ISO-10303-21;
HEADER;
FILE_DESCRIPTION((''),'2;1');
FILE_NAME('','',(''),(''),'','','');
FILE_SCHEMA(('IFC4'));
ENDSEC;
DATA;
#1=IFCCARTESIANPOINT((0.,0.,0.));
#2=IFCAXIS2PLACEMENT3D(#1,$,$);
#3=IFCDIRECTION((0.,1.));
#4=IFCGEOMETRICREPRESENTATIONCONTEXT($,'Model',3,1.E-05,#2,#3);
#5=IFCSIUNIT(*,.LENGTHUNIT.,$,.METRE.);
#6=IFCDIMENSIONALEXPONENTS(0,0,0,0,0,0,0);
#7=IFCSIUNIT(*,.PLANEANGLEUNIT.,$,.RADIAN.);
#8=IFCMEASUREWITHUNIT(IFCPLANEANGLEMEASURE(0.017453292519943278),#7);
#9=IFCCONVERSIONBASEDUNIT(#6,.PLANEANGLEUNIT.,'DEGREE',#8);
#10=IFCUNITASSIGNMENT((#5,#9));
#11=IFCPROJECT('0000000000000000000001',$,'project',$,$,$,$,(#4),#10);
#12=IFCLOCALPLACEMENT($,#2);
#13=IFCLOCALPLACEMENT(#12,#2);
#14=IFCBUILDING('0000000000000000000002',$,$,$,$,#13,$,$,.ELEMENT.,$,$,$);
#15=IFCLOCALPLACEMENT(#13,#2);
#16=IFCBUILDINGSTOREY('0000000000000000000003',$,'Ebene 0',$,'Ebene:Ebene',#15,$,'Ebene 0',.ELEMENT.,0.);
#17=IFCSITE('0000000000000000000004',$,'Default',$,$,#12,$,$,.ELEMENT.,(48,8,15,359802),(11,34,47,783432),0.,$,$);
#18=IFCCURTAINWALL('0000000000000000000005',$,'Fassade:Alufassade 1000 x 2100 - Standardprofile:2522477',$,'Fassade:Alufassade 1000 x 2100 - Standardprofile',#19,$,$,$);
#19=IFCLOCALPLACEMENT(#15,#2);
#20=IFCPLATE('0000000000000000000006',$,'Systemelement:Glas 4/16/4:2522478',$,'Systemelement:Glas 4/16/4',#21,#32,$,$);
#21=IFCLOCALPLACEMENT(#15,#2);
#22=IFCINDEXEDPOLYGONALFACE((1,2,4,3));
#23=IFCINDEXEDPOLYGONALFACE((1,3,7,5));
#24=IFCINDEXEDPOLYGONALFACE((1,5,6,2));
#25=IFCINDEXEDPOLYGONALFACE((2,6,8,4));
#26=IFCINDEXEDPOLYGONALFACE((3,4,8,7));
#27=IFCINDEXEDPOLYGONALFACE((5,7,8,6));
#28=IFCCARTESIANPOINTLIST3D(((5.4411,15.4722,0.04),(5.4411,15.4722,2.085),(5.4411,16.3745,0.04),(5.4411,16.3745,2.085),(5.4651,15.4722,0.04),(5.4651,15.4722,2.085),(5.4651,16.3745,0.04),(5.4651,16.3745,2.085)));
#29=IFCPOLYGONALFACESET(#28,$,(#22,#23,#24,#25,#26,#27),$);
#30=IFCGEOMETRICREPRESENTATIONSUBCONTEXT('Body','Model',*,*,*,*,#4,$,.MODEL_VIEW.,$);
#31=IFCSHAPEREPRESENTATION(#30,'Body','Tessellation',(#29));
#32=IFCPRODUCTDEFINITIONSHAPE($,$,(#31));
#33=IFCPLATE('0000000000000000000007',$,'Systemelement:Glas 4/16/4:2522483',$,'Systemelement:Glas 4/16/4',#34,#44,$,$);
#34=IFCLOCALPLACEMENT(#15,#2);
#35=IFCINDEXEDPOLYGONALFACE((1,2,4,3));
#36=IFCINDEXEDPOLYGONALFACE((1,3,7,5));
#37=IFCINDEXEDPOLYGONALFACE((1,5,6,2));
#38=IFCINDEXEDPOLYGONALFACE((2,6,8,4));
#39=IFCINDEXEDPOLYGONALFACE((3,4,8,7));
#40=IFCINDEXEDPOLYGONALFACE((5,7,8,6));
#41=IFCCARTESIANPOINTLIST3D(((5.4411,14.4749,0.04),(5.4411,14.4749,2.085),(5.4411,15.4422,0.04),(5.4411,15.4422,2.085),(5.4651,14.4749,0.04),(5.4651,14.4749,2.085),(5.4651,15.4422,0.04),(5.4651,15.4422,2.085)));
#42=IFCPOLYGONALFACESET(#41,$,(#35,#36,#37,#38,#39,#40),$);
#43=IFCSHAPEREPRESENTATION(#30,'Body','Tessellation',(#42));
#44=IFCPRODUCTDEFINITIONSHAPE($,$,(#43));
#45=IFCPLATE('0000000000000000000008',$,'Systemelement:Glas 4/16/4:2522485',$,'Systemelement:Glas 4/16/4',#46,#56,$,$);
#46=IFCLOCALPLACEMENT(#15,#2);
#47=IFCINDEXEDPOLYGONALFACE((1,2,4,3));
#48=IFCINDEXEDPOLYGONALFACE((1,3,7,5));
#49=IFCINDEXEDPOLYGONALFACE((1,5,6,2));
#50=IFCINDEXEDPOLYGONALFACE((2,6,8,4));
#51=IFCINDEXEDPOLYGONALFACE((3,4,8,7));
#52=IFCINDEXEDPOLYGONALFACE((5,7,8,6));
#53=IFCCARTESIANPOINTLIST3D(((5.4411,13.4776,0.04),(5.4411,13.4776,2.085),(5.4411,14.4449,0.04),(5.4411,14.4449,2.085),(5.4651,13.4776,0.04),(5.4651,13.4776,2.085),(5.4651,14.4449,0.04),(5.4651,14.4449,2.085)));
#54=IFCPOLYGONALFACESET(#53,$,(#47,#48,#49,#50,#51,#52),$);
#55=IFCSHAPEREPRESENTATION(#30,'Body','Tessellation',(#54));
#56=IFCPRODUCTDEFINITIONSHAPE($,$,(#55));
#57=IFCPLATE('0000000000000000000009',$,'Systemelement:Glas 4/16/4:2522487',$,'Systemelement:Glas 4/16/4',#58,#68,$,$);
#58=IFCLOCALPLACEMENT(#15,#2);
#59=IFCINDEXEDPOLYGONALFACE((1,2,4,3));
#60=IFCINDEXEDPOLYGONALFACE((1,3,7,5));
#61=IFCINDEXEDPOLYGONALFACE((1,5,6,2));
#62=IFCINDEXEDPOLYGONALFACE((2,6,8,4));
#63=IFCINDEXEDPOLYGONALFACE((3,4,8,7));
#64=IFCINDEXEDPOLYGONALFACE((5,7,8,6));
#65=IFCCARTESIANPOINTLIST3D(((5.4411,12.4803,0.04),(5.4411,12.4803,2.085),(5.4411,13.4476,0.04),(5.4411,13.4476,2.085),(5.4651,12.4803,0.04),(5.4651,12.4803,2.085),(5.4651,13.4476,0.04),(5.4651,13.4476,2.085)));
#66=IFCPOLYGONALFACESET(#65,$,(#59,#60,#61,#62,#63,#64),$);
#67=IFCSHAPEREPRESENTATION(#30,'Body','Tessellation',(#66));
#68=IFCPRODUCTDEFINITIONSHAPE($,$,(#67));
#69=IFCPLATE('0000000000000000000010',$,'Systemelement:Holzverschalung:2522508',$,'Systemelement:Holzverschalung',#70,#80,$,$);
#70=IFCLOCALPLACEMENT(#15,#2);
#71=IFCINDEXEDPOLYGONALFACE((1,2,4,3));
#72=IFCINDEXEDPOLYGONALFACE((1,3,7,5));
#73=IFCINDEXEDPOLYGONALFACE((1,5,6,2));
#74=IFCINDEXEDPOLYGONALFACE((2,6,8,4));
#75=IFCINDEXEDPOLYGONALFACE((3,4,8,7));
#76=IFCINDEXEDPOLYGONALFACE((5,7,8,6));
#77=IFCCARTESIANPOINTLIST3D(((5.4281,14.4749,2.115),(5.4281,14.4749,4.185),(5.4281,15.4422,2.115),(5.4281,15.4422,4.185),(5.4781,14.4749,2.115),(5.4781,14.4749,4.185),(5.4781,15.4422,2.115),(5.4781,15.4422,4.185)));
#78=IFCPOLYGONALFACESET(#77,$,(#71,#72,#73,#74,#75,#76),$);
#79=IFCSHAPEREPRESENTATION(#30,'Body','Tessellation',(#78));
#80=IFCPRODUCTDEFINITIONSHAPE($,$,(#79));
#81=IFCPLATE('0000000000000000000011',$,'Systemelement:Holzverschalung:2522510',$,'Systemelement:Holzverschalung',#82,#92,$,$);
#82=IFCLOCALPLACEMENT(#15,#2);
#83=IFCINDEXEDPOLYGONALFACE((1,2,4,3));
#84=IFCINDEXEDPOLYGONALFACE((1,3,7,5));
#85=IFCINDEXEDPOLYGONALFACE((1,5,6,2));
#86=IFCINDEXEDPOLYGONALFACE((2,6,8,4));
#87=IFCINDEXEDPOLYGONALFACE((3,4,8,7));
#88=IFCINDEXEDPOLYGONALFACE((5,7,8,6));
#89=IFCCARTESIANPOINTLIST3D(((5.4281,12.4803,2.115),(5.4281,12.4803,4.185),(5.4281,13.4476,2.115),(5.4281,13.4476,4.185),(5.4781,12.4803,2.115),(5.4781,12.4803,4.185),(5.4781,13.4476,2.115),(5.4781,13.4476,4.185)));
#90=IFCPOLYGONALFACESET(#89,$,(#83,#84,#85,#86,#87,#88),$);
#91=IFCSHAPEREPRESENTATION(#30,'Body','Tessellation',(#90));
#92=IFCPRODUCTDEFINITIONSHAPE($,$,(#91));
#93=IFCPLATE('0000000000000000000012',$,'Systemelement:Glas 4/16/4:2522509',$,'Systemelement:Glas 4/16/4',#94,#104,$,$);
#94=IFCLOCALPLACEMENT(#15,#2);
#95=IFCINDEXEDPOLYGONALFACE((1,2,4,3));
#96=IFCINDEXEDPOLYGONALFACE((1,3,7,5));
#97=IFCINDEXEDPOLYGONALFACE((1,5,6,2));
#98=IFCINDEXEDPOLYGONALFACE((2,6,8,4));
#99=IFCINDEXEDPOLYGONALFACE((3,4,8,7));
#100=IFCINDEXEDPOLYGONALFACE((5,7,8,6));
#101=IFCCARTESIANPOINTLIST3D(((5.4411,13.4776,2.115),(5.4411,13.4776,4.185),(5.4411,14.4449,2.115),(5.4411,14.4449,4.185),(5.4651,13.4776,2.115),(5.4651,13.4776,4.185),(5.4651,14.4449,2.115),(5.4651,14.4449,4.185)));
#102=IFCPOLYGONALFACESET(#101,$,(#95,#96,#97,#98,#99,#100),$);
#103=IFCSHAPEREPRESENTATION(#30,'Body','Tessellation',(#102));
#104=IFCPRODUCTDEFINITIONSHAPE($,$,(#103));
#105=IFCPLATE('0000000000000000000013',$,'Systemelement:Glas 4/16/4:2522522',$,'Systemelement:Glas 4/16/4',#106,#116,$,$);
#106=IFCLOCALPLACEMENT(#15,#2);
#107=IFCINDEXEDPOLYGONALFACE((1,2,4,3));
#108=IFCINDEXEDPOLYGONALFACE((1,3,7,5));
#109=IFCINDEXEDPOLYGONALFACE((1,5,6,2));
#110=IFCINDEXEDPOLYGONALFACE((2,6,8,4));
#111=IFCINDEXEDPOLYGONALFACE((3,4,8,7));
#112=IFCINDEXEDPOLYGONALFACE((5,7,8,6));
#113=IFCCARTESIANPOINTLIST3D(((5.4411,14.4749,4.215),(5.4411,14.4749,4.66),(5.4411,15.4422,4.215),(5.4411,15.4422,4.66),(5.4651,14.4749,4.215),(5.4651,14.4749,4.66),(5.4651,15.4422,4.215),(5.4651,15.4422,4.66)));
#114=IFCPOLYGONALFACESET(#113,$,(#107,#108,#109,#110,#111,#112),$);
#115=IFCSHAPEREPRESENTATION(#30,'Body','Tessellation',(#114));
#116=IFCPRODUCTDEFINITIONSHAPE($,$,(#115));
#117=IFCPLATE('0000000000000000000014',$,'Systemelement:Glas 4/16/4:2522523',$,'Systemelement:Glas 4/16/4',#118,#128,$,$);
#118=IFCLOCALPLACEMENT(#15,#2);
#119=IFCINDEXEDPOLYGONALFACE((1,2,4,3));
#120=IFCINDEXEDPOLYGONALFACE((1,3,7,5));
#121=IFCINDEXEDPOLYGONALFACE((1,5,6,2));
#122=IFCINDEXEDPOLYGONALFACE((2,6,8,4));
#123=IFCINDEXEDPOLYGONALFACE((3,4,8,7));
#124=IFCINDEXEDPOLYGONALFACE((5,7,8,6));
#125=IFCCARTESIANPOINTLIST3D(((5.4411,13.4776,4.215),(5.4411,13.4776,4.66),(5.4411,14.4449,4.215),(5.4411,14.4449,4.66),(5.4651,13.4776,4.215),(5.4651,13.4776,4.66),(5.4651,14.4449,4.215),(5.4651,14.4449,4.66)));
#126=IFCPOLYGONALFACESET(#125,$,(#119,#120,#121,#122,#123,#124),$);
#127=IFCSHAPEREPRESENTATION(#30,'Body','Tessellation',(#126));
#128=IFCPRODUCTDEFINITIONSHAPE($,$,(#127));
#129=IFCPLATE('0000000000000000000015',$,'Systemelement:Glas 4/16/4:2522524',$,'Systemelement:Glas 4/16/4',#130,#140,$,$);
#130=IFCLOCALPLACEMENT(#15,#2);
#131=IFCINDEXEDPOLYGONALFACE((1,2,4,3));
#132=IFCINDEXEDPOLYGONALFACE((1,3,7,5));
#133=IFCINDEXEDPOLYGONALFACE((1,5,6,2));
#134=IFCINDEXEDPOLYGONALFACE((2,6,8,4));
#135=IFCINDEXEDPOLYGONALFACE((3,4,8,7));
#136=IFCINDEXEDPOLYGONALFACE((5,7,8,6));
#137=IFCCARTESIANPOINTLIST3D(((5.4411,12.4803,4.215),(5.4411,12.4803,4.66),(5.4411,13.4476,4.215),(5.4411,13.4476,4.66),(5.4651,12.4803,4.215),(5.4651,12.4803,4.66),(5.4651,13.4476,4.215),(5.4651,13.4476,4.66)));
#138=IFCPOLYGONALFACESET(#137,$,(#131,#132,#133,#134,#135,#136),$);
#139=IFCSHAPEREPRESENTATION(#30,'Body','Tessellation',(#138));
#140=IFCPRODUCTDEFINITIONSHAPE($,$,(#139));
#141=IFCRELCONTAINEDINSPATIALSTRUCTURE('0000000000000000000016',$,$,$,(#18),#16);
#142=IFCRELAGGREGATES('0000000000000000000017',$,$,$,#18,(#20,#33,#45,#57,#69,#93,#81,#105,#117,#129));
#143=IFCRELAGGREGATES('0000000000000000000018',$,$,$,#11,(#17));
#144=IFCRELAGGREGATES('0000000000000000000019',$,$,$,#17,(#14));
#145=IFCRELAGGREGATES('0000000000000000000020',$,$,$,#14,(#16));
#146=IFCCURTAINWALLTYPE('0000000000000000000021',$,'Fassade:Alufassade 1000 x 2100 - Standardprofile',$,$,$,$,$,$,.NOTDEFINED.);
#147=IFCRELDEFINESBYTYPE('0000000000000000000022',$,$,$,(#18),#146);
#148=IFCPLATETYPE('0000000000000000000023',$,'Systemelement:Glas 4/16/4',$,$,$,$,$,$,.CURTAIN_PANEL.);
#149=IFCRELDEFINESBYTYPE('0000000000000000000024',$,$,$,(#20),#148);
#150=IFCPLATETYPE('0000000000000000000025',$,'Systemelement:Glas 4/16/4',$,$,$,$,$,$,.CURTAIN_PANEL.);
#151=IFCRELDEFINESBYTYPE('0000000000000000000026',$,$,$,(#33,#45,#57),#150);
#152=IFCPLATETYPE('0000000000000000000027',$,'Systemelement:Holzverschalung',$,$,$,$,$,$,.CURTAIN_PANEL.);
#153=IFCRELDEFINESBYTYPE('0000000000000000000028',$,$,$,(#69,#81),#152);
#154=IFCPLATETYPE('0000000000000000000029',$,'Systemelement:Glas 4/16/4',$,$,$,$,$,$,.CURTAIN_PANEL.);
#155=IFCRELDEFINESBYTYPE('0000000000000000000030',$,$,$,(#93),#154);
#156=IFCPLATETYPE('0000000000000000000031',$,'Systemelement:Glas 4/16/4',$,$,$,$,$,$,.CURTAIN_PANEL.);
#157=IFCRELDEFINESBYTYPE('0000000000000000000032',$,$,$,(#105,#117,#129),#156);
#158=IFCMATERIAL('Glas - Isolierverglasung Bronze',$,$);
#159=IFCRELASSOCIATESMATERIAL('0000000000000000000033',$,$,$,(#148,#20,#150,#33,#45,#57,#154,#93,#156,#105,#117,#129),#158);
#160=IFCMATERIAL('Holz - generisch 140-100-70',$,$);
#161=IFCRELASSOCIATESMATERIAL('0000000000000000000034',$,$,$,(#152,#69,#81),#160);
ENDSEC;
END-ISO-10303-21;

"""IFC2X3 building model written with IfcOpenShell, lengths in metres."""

from ifc_helpers import new_model, entity, si_unit, converted_unit, direction, frame, origin, origin_2d_with_axis, place, context, subcontext, project, spatial, rectangle, extrude, source, transform, mapped, material, type_object, type_shapes, element, aggregate, save


model = new_model("IFC2X3")

# Units and contexts
model_context = context("Model", 3, precision=1e-05, world=origin(), true_north=direction((0.0, 1.0)))
body_context = subcontext(model_context, "Body", "Model", "MODEL_VIEW")
ifc_project = project(units=[si_unit("LENGTHUNIT", "METRE"), converted_unit("PLANEANGLEUNIT", "DEGREE", entity("IfcPlaneAngleMeasure", 0.017453292519943278), si_unit("PLANEANGLEUNIT", "RADIAN"), dimensions=[0, 0, 0, 0, 0, 0, 0])], contexts=[model_context])

# Site, building, storey
site_placement = place(None, origin())
site = spatial("IfcSite", under=ifc_project, at=site_placement, Name="Default", CompositionType="ELEMENT", RefLatitude=(48, 8, 15, 359802), RefLongitude=(11, 34, 47, 783432), RefElevation=0.0)
building_placement = place(site_placement, origin())
building = spatial("IfcBuilding", under=site, at=building_placement, CompositionType="ELEMENT")
storey_placement = place(building_placement, origin())
storey = spatial("IfcBuildingStorey", under=building, at=storey_placement, Name="Ebene 0", ObjectType="Ebene:Ebene", LongName="Ebene 0", CompositionType="ELEMENT", Elevation=0.0)

# Curtain wall, plates
curtain_wall_type = type_object("IfcCurtainWallType", Name="Fassade:Alufassade 1000 x 2100 - Standardprofile", PredefinedType="NOTDEFINED")
curtain_wall_placement = place(storey_placement, origin())
curtain_wall = element("IfcCurtainWall", 1, at=curtain_wall_placement, inside=storey, type_object=curtain_wall_type, Name="Fassade:Alufassade 1000 x 2100 - Standardprofile:2522477", ObjectType="Fassade:Alufassade 1000 x 2100 - Standardprofile")
ifc_material_1 = material(Name="Glas - Isolierverglasung Bronze")
plate_type_1 = type_object("IfcPlateType", Name="Systemelement:Glas 4/16/4", PredefinedType="CURTAIN_PANEL", material=ifc_material_1)
shared_shape_1 = source(origin(), body_context, "Body", "SweptSolid", [
    extrude(rectangle(XDim=0.024, YDim=0.9023, at=origin_2d_with_axis()), frame((0.0, 0.0, 0.0), z_axis=(0.0, 0.0, 1.0), x_axis=(0.0, 1.0, 0.0)), (0.0, 0.0, 1.0), 2.045),
])
type_shapes(plate_type_1, [shared_shape_1])
plate_1_placement = place(curtain_wall_placement, frame((5.4531, 15.9233, 0.04), z_axis=(0.0, 0.0, 1.0), x_axis=(0.0, -1.0, 0.0)))
plate_1 = element("IfcPlate", 2, at=plate_1_placement, type_object=plate_type_1, material=ifc_material_1, Name="Systemelement:Glas 4/16/4:2522478", ObjectType="Systemelement:Glas 4/16/4", context=body_context, shape_type="MappedRepresentation", body=[
    mapped(shared_shape_1, transform((0.0, 0.0, 0.0), scale=1.0)),
])
plate_type_2 = type_object("IfcPlateType", Name="Systemelement:Glas 4/16/4", PredefinedType="CURTAIN_PANEL", material=ifc_material_1)
shared_shape_2 = source(origin(), body_context, "Body", "SweptSolid", [
    extrude(rectangle(XDim=0.024, YDim=0.9673, at=origin_2d_with_axis()), frame((0.0, 0.0, 0.0), z_axis=(0.0, 0.0, 1.0), x_axis=(0.0, 1.0, 0.0)), (0.0, 0.0, 1.0), 2.045),
])
type_shapes(plate_type_2, [shared_shape_2])
plate_2_placement = place(curtain_wall_placement, frame((5.4531, 14.9585, 0.04), z_axis=(0.0, 0.0, 1.0), x_axis=(0.0, -1.0, 0.0)))
plate_2 = element("IfcPlate", 3, at=plate_2_placement, type_object=plate_type_2, material=ifc_material_1, Name="Systemelement:Glas 4/16/4:2522483", ObjectType="Systemelement:Glas 4/16/4", context=body_context, shape_type="MappedRepresentation", body=[
    mapped(shared_shape_2, transform((0.0, 0.0, 0.0), scale=1.0)),
])
plate_3_placement = place(curtain_wall_placement, frame((5.4531, 13.9612, 0.04), z_axis=(0.0, 0.0, 1.0), x_axis=(0.0, -1.0, 0.0)))
plate_3 = element("IfcPlate", 4, at=plate_3_placement, type_object=plate_type_2, material=ifc_material_1, Name="Systemelement:Glas 4/16/4:2522485", ObjectType="Systemelement:Glas 4/16/4", context=body_context, shape_type="MappedRepresentation", body=[
    mapped(shared_shape_2, transform((0.0, 0.0, 0.0), scale=1.0)),
])
plate_4_placement = place(curtain_wall_placement, frame((5.4531, 12.9639, 0.04), z_axis=(0.0, 0.0, 1.0), x_axis=(0.0, -1.0, 0.0)))
plate_4 = element("IfcPlate", 5, at=plate_4_placement, type_object=plate_type_2, material=ifc_material_1, Name="Systemelement:Glas 4/16/4:2522487", ObjectType="Systemelement:Glas 4/16/4", context=body_context, shape_type="MappedRepresentation", body=[
    mapped(shared_shape_2, transform((0.0, 0.0, 0.0), scale=1.0)),
])
ifc_material_2 = material(Name="Holz - generisch 140-100-70")
plate_type_3 = type_object("IfcPlateType", Name="Systemelement:Holzverschalung", PredefinedType="CURTAIN_PANEL", material=ifc_material_2)
shared_shape_3 = source(origin(), body_context, "Body", "SweptSolid", [
    extrude(rectangle(XDim=0.05, YDim=0.9673, at=origin_2d_with_axis()), frame((0.0, 0.0, 0.0), z_axis=(0.0, 0.0, 1.0), x_axis=(0.0, 1.0, 0.0)), (0.0, 0.0, 1.0), 2.07),
])
type_shapes(plate_type_3, [shared_shape_3])
plate_5_placement = place(curtain_wall_placement, frame((5.4531, 14.9585, 2.115), z_axis=(0.0, 0.0, 1.0), x_axis=(0.0, -1.0, 0.0)))
plate_5 = element("IfcPlate", 6, at=plate_5_placement, type_object=plate_type_3, material=ifc_material_2, Name="Systemelement:Holzverschalung:2522508", ObjectType="Systemelement:Holzverschalung", context=body_context, shape_type="MappedRepresentation", body=[
    mapped(shared_shape_3, transform((0.0, 0.0, 0.0), scale=1.0)),
])
plate_6_placement = place(curtain_wall_placement, frame((5.4531, 12.9639, 2.115), z_axis=(0.0, 0.0, 1.0), x_axis=(0.0, -1.0, 0.0)))
plate_6 = element("IfcPlate", 7, at=plate_6_placement, type_object=plate_type_3, material=ifc_material_2, Name="Systemelement:Holzverschalung:2522510", ObjectType="Systemelement:Holzverschalung", context=body_context, shape_type="MappedRepresentation", body=[
    mapped(shared_shape_3, transform((0.0, 0.0, 0.0), scale=1.0)),
])
plate_type_4 = type_object("IfcPlateType", Name="Systemelement:Glas 4/16/4", PredefinedType="CURTAIN_PANEL", material=ifc_material_1)
shared_shape_4 = source(origin(), body_context, "Body", "SweptSolid", [
    extrude(rectangle(XDim=0.024, YDim=0.9673, at=origin_2d_with_axis()), frame((0.0, 0.0, 0.0), z_axis=(0.0, 0.0, 1.0), x_axis=(0.0, 1.0, 0.0)), (0.0, 0.0, 1.0), 2.07),
])
type_shapes(plate_type_4, [shared_shape_4])
plate_7_placement = place(curtain_wall_placement, frame((5.4531, 13.9612, 2.115), z_axis=(0.0, 0.0, 1.0), x_axis=(0.0, -1.0, 0.0)))
plate_7 = element("IfcPlate", 8, at=plate_7_placement, type_object=plate_type_4, material=ifc_material_1, Name="Systemelement:Glas 4/16/4:2522509", ObjectType="Systemelement:Glas 4/16/4", context=body_context, shape_type="MappedRepresentation", body=[
    mapped(shared_shape_4, transform((0.0, 0.0, 0.0), scale=1.0)),
])
plate_type_5 = type_object("IfcPlateType", Name="Systemelement:Glas 4/16/4", PredefinedType="CURTAIN_PANEL", material=ifc_material_1)
shared_shape_5 = source(origin(), body_context, "Body", "SweptSolid", [
    extrude(rectangle(XDim=0.024, YDim=0.9673, at=origin_2d_with_axis()), frame((0.0, 0.0, 0.0), z_axis=(0.0, 0.0, 1.0), x_axis=(0.0, 1.0, 0.0)), (0.0, 0.0, 1.0), 0.445),
])
type_shapes(plate_type_5, [shared_shape_5])
plate_8_placement = place(curtain_wall_placement, frame((5.4531, 14.9585, 4.215), z_axis=(0.0, 0.0, 1.0), x_axis=(0.0, -1.0, 0.0)))
plate_8 = element("IfcPlate", 9, at=plate_8_placement, type_object=plate_type_5, material=ifc_material_1, Name="Systemelement:Glas 4/16/4:2522522", ObjectType="Systemelement:Glas 4/16/4", context=body_context, shape_type="MappedRepresentation", body=[
    mapped(shared_shape_5, transform((0.0, 0.0, 0.0), scale=1.0)),
])
plate_9_placement = place(curtain_wall_placement, frame((5.4531, 13.9612, 4.215), z_axis=(0.0, 0.0, 1.0), x_axis=(0.0, -1.0, 0.0)))
plate_9 = element("IfcPlate", 10, at=plate_9_placement, type_object=plate_type_5, material=ifc_material_1, Name="Systemelement:Glas 4/16/4:2522523", ObjectType="Systemelement:Glas 4/16/4", context=body_context, shape_type="MappedRepresentation", body=[
    mapped(shared_shape_5, transform((0.0, 0.0, 0.0), scale=1.0)),
])
plate_10_placement = place(curtain_wall_placement, frame((5.4531, 12.9639, 4.215), z_axis=(0.0, 0.0, 1.0), x_axis=(0.0, -1.0, 0.0)))
plate_10 = element("IfcPlate", 11, at=plate_10_placement, type_object=plate_type_5, material=ifc_material_1, Name="Systemelement:Glas 4/16/4:2522524", ObjectType="Systemelement:Glas 4/16/4", context=body_context, shape_type="MappedRepresentation", body=[
    mapped(shared_shape_5, transform((0.0, 0.0, 0.0), scale=1.0)),
])
aggregate(curtain_wall, [plate_1, plate_2, plate_3, plate_4, plate_5, plate_7, plate_6, plate_8, plate_9, plate_10])

save(model, "model.ifc")
